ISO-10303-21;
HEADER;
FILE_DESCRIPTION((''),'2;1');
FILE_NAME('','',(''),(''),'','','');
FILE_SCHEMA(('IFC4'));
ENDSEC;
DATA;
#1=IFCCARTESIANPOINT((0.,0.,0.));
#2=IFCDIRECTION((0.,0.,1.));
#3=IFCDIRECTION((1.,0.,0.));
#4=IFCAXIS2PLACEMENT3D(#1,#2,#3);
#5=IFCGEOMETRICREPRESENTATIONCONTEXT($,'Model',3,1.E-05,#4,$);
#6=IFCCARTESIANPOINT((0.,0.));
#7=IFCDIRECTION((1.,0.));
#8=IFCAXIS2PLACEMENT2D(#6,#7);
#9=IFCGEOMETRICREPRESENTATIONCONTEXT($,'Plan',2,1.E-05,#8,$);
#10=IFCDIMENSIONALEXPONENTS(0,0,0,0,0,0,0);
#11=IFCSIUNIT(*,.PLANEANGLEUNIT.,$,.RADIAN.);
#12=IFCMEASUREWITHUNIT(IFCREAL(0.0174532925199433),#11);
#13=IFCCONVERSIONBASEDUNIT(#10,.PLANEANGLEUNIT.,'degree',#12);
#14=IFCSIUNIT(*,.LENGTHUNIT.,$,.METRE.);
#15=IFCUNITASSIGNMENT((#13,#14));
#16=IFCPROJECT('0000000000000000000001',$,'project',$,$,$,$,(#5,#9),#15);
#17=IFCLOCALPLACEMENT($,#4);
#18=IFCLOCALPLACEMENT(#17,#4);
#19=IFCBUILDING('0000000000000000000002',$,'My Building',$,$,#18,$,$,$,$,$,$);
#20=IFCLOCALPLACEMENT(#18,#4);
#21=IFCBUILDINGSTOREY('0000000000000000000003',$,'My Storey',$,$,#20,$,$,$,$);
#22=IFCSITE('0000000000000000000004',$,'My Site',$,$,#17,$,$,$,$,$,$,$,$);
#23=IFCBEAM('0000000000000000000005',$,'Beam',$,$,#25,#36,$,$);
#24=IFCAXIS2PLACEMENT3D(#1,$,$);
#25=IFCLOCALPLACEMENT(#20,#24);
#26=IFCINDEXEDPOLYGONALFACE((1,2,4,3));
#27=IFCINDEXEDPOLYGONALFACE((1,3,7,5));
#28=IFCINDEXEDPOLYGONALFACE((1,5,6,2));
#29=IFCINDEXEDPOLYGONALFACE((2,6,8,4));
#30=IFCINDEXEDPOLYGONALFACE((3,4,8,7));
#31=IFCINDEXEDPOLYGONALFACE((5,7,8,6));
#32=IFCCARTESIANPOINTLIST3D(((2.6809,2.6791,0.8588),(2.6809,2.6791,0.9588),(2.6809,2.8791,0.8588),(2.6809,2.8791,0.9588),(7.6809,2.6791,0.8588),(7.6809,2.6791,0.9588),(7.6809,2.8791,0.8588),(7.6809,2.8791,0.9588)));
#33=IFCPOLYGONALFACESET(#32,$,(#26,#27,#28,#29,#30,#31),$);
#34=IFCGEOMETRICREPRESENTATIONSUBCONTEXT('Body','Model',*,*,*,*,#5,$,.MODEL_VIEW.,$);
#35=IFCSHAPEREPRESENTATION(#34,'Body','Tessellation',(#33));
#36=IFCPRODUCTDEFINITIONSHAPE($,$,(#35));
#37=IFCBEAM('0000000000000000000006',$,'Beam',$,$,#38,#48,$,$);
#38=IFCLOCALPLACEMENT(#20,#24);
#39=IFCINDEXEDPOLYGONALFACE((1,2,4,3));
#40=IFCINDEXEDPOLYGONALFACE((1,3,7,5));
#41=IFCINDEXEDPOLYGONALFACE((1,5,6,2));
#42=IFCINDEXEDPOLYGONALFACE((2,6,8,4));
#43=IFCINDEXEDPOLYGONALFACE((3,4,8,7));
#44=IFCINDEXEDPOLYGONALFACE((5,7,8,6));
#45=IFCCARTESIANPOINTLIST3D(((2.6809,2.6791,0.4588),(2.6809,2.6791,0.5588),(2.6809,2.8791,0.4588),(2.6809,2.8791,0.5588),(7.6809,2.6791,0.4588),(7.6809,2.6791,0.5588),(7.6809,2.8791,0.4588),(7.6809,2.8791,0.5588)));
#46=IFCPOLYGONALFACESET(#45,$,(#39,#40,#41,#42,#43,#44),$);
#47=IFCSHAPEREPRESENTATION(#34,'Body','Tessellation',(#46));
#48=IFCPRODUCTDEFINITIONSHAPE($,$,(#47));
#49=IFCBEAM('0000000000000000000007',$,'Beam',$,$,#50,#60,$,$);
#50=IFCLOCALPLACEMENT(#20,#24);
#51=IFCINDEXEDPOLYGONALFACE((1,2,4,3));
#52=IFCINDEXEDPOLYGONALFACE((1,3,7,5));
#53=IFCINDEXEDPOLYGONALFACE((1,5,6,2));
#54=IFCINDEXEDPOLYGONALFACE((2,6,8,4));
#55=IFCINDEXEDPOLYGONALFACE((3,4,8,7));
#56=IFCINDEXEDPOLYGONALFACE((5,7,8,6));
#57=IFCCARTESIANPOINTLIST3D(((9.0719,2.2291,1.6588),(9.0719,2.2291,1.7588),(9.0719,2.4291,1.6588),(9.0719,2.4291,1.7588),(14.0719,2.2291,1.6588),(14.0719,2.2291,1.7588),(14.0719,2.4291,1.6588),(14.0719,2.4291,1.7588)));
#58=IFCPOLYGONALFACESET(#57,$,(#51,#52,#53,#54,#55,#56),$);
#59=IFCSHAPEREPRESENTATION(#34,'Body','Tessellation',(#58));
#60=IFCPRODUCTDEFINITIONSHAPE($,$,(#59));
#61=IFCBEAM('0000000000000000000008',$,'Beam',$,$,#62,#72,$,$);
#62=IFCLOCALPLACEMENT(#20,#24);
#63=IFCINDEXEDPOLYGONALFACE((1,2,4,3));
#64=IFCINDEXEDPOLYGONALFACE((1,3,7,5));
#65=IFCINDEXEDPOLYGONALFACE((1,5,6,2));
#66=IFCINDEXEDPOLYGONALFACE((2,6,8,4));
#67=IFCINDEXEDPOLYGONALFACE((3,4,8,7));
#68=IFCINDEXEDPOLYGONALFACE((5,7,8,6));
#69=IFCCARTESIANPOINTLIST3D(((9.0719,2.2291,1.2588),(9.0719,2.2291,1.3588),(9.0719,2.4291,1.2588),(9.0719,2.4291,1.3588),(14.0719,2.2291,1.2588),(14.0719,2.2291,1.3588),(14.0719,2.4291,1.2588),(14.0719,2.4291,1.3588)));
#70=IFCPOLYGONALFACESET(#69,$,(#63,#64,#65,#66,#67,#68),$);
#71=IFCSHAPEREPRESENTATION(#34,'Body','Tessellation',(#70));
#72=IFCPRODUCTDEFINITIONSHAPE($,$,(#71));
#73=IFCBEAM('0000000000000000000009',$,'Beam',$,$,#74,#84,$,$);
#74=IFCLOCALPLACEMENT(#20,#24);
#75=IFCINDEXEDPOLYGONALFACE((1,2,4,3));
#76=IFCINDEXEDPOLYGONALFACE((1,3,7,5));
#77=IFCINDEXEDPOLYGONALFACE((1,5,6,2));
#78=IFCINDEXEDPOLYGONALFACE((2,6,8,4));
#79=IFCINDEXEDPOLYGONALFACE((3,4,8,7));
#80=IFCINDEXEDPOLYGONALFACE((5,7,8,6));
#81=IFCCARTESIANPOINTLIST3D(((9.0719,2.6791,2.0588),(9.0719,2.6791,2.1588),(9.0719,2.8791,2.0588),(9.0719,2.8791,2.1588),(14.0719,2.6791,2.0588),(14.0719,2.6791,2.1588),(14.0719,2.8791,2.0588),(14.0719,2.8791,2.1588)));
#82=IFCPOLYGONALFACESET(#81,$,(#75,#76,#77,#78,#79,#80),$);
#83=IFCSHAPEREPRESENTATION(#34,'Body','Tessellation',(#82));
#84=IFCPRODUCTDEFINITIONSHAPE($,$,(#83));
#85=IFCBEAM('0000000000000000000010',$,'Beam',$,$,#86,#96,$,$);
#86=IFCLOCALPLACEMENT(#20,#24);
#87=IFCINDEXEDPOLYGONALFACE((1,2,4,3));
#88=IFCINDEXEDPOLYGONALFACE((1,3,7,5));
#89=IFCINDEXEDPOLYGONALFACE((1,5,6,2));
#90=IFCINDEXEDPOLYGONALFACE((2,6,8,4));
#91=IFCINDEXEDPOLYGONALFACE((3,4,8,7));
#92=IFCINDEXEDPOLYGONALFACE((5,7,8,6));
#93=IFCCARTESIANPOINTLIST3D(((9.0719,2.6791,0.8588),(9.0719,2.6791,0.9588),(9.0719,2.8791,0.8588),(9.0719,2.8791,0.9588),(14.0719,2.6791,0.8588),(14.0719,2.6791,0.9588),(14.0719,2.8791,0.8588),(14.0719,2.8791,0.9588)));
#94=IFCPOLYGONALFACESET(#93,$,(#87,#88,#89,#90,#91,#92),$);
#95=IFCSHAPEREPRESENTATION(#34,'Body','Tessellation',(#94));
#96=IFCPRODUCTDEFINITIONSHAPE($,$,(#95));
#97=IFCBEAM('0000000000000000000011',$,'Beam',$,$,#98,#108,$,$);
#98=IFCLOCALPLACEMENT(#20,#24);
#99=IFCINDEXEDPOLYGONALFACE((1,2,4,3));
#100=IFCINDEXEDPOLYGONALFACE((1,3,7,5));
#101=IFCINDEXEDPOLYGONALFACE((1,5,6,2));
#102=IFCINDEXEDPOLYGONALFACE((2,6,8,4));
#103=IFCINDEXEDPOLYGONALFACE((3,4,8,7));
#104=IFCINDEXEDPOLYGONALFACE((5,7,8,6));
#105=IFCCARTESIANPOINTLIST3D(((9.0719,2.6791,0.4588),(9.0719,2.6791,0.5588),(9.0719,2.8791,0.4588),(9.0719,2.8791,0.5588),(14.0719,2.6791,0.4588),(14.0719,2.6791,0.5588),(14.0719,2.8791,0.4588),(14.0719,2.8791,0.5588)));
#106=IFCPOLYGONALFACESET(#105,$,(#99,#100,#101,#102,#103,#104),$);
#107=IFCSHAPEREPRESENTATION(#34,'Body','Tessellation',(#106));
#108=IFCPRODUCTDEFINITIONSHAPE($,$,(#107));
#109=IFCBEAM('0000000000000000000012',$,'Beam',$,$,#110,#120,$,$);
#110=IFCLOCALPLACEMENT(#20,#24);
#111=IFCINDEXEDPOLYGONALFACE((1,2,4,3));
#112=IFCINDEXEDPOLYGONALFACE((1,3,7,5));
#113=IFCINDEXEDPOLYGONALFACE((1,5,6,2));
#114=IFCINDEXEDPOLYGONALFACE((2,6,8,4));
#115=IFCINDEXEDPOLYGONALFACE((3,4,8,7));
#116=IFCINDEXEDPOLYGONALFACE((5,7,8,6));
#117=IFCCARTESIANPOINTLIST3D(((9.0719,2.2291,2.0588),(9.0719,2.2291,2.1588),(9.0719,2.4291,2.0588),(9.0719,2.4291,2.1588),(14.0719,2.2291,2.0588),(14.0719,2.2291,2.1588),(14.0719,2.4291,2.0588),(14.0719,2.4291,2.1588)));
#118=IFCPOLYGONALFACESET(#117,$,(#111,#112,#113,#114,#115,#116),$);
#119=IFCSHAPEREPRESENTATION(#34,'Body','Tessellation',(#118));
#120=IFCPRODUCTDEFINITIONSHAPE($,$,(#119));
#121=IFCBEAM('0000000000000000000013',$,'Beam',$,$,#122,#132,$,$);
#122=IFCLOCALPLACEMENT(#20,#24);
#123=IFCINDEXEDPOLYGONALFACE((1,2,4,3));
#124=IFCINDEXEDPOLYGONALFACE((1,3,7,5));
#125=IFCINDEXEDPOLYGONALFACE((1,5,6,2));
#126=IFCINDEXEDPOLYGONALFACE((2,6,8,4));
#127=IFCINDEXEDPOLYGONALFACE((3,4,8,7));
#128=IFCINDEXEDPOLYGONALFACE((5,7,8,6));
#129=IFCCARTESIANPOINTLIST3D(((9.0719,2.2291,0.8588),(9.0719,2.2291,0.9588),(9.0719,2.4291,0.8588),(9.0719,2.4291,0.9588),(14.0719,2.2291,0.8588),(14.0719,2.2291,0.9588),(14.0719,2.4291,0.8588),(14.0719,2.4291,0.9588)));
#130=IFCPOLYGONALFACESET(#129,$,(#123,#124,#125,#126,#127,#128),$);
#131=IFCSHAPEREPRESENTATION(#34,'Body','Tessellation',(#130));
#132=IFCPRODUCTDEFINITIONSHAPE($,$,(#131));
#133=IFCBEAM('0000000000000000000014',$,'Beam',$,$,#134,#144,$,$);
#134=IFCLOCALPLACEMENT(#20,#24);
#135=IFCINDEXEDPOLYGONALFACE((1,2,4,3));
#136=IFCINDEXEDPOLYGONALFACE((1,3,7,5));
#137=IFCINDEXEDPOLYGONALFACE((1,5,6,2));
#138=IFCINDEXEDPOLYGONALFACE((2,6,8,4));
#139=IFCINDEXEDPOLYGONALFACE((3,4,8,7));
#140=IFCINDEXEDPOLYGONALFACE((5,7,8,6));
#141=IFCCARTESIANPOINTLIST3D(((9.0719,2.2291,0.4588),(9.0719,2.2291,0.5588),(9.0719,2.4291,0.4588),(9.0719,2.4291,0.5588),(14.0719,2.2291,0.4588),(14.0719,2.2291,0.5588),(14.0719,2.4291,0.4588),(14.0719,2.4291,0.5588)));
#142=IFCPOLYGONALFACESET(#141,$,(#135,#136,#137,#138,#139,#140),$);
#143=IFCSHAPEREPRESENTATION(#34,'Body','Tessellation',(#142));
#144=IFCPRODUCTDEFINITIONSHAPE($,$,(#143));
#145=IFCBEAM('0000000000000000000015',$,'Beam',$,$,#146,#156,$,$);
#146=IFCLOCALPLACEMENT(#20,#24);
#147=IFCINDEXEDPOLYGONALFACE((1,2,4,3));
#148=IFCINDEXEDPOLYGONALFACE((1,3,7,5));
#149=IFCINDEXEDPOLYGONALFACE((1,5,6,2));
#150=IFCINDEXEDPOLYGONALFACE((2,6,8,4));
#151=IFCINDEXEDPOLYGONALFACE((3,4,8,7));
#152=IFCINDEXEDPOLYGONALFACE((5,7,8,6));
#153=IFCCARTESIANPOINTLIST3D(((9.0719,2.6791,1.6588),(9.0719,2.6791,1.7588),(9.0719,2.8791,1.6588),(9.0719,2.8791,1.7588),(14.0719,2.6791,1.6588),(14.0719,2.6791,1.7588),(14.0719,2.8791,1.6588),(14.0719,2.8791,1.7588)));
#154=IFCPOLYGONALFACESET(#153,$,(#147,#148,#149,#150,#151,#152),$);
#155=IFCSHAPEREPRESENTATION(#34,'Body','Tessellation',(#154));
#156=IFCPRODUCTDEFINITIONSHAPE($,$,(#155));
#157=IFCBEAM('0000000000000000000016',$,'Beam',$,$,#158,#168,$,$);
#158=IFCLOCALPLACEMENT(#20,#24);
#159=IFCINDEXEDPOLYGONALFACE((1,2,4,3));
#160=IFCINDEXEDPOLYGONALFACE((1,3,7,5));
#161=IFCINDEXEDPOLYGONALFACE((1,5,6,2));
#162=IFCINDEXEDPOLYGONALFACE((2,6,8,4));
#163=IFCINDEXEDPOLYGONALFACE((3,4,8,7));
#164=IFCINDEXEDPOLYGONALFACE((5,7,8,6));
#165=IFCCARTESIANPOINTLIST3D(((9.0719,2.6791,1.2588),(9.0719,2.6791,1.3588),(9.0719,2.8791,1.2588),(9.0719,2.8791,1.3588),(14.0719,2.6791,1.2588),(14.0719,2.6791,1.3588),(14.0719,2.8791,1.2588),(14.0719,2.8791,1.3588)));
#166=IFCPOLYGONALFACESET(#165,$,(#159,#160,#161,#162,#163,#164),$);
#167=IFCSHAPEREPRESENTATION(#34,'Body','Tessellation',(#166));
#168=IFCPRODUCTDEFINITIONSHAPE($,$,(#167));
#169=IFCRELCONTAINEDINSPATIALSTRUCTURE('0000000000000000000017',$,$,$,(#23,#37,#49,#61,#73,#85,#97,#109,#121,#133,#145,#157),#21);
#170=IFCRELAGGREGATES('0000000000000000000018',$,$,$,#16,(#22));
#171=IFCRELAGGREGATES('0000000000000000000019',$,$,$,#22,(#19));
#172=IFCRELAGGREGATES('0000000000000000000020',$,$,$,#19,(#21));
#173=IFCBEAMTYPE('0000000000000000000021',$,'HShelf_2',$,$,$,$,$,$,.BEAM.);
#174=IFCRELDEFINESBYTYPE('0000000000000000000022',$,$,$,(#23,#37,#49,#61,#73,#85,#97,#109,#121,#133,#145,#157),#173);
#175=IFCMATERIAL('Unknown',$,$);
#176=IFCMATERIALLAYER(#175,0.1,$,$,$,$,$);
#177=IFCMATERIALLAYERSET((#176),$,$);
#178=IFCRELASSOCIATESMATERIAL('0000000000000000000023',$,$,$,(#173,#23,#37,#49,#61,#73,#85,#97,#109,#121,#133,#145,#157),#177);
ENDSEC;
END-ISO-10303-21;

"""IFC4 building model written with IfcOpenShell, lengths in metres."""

from ifc_helpers import new_model, entity, si_unit, converted_unit, frame, origin_with_axes, origin_2d_with_axis, place, context, subcontext, project, spatial, indexed_curve, outline, extrude, material, layer, layer_set, layer_usage, type_object, element, save


model = new_model("IFC4")

# Units and contexts
model_context = context("Model", 3, precision=1e-05, world=origin_with_axes())
plan_context = context("Plan", 2, precision=1e-05, world=origin_2d_with_axis())
body_context_1 = subcontext(model_context, "Body", "Model", "MODEL_VIEW")
ifc_project = project(units=[converted_unit("PLANEANGLEUNIT", "degree", entity("IfcReal", 0.0174532925199433), si_unit("PLANEANGLEUNIT", "RADIAN"), dimensions=[0, 0, 0, 0, 0, 0, 0]), si_unit("LENGTHUNIT", "METRE")], contexts=[model_context, plan_context])

# Site, building, storey
site_placement = place(None, origin_with_axes())
site = spatial("IfcSite", under=ifc_project, at=site_placement, Name="My Site")
building_placement = place(site_placement, origin_with_axes())
building = spatial("IfcBuilding", under=site, at=building_placement, Name="My Building")
storey_placement = place(building_placement, origin_with_axes())
storey = spatial("IfcBuildingStorey", under=building, at=storey_placement, Name="My Storey")

# Shared definitions
ifc_material = material(Name="Unknown")

# Beams
ifc_layer_1 = layer(ifc_material, 0.1)
ifc_layer_set_1 = layer_set([ifc_layer_1])
beam_type_1 = type_object("IfcBeamType", Name="HShelf_2", PredefinedType="BEAM", material=ifc_layer_set_1)
ifc_layer_usage_1 = layer_usage(ifc_layer_set_1, "AXIS3", "POSITIVE", -0.1)
beam_1_placement = place(storey_placement, frame((2.6809, 2.8791, 0.9588), z_axis=(0.0, 0.0, 1.0), x_axis=(1.0, 0.0, 0.0)))
element("IfcBeam", 1, at=beam_1_placement, inside=storey, type_object=beam_type_1, material=ifc_layer_usage_1, Name="Beam", context=body_context_1, shape_type="SweptSolid", body=[
    extrude(outline(indexed_curve([(0.0, 0.0), (0.0, -0.2), (5.0, -0.2), (5.0, 0.0), (0.0, 0.0)])), frame((0.0, 0.0, -0.1), z_axis=(0.0, 0.0, 1.0), x_axis=(1.0, 0.0, 0.0)), (0.0, 0.0, 1.0), 0.1),
])
ifc_layer_usage_2 = layer_usage(ifc_layer_set_1, "AXIS3", "POSITIVE", -0.1)
beam_2_placement = place(storey_placement, frame((2.6809, 2.8791, 0.5588), z_axis=(0.0, 0.0, 1.0), x_axis=(1.0, 0.0, 0.0)))
element("IfcBeam", 2, at=beam_2_placement, inside=storey, type_object=beam_type_1, material=ifc_layer_usage_2, Name="Beam", context=body_context_1, shape_type="SweptSolid", body=[
    extrude(outline(indexed_curve([(0.0, 0.0), (0.0, -0.2), (5.0, -0.2), (5.0, 0.0), (0.0, 0.0)])), frame((0.0, 0.0, -0.1), z_axis=(0.0, 0.0, 1.0), x_axis=(1.0, 0.0, 0.0)), (0.0, 0.0, 1.0), 0.1),
])
ifc_layer_usage_3 = layer_usage(ifc_layer_set_1, "AXIS3", "POSITIVE", -0.1)
beam_3_placement = place(storey_placement, frame((9.0719, 2.4291, 1.7588), z_axis=(0.0, 0.0, 1.0), x_axis=(1.0, 0.0, 0.0)))
element("IfcBeam", 3, at=beam_3_placement, inside=storey, type_object=beam_type_1, material=ifc_layer_usage_3, Name="Beam", context=body_context_1, shape_type="SweptSolid", body=[
    extrude(outline(indexed_curve([(0.0, 0.0), (0.0, -0.2), (5.0, -0.2), (5.0, 0.0), (0.0, 0.0)])), frame((0.0, 0.0, -0.1), z_axis=(0.0, 0.0, 1.0), x_axis=(1.0, 0.0, 0.0)), (0.0, 0.0, 1.0), 0.1),
])
ifc_layer_usage_4 = layer_usage(ifc_layer_set_1, "AXIS3", "POSITIVE", -0.1)
beam_4_placement = place(storey_placement, frame((9.0719, 2.4291, 1.3588), z_axis=(0.0, 0.0, 1.0), x_axis=(1.0, 0.0, 0.0)))
element("IfcBeam", 4, at=beam_4_placement, inside=storey, type_object=beam_type_1, material=ifc_layer_usage_4, Name="Beam", context=body_context_1, shape_type="SweptSolid", body=[
    extrude(outline(indexed_curve([(0.0, 0.0), (0.0, -0.2), (5.0, -0.2), (5.0, 0.0), (0.0, 0.0)])), frame((0.0, 0.0, -0.1), z_axis=(0.0, 0.0, 1.0), x_axis=(1.0, 0.0, 0.0)), (0.0, 0.0, 1.0), 0.1),
])
ifc_layer_usage_5 = layer_usage(ifc_layer_set_1, "AXIS3", "POSITIVE", -0.1)
beam_5_placement = place(storey_placement, frame((9.0719, 2.8791, 2.1588), z_axis=(0.0, 0.0, 1.0), x_axis=(1.0, 0.0, 0.0)))
element("IfcBeam", 5, at=beam_5_placement, inside=storey, type_object=beam_type_1, material=ifc_layer_usage_5, Name="Beam", context=body_context_1, shape_type="SweptSolid", body=[
    extrude(outline(indexed_curve([(0.0, 0.0), (0.0, -0.2), (5.0, -0.2), (5.0, 0.0), (0.0, 0.0)])), frame((0.0, 0.0, -0.1), z_axis=(0.0, 0.0, 1.0), x_axis=(1.0, 0.0, 0.0)), (0.0, 0.0, 1.0), 0.1),
])
ifc_layer_usage_6 = layer_usage(ifc_layer_set_1, "AXIS3", "POSITIVE", -0.1)
beam_6_placement = place(storey_placement, frame((9.0719, 2.8791, 0.9588), z_axis=(0.0, 0.0, 1.0), x_axis=(1.0, 0.0, 0.0)))
element("IfcBeam", 6, at=beam_6_placement, inside=storey, type_object=beam_type_1, material=ifc_layer_usage_6, Name="Beam", context=body_context_1, shape_type="SweptSolid", body=[
    extrude(outline(indexed_curve([(0.0, 0.0), (0.0, -0.2), (5.0, -0.2), (5.0, 0.0), (0.0, 0.0)])), frame((0.0, 0.0, -0.1), z_axis=(0.0, 0.0, 1.0), x_axis=(1.0, 0.0, 0.0)), (0.0, 0.0, 1.0), 0.1),
])
ifc_layer_usage_7 = layer_usage(ifc_layer_set_1, "AXIS3", "POSITIVE", -0.1)
beam_7_placement = place(storey_placement, frame((9.0719, 2.8791, 0.5588), z_axis=(0.0, 0.0, 1.0), x_axis=(1.0, 0.0, 0.0)))
element("IfcBeam", 7, at=beam_7_placement, inside=storey, type_object=beam_type_1, material=ifc_layer_usage_7, Name="Beam", context=body_context_1, shape_type="SweptSolid", body=[
    extrude(outline(indexed_curve([(0.0, 0.0), (0.0, -0.2), (5.0, -0.2), (5.0, 0.0), (0.0, 0.0)])), frame((0.0, 0.0, -0.1), z_axis=(0.0, 0.0, 1.0), x_axis=(1.0, 0.0, 0.0)), (0.0, 0.0, 1.0), 0.1),
])
ifc_layer_usage_8 = layer_usage(ifc_layer_set_1, "AXIS3", "POSITIVE", -0.1)
beam_8_placement = place(storey_placement, frame((9.0719, 2.4291, 2.1588), z_axis=(0.0, 0.0, 1.0), x_axis=(1.0, 0.0, 0.0)))
element("IfcBeam", 8, at=beam_8_placement, inside=storey, type_object=beam_type_1, material=ifc_layer_usage_8, Name="Beam", context=body_context_1, shape_type="SweptSolid", body=[
    extrude(outline(indexed_curve([(0.0, 0.0), (0.0, -0.2), (5.0, -0.2), (5.0, 0.0), (0.0, 0.0)])), frame((0.0, 0.0, -0.1), z_axis=(0.0, 0.0, 1.0), x_axis=(1.0, 0.0, 0.0)), (0.0, 0.0, 1.0), 0.1),
])
ifc_layer_usage_9 = layer_usage(ifc_layer_set_1, "AXIS3", "POSITIVE", -0.1)
beam_9_placement = place(storey_placement, frame((9.0719, 2.4291, 0.9588), z_axis=(0.0, 0.0, 1.0), x_axis=(1.0, 0.0, 0.0)))
element("IfcBeam", 9, at=beam_9_placement, inside=storey, type_object=beam_type_1, material=ifc_layer_usage_9, Name="Beam", context=body_context_1, shape_type="SweptSolid", body=[
    extrude(outline(indexed_curve([(0.0, 0.0), (0.0, -0.2), (5.0, -0.2), (5.0, 0.0), (0.0, 0.0)])), frame((0.0, 0.0, -0.1), z_axis=(0.0, 0.0, 1.0), x_axis=(1.0, 0.0, 0.0)), (0.0, 0.0, 1.0), 0.1),
])
ifc_layer_usage_10 = layer_usage(ifc_layer_set_1, "AXIS3", "POSITIVE", -0.1)
beam_10_placement = place(storey_placement, frame((9.0719, 2.4291, 0.5588), z_axis=(0.0, 0.0, 1.0), x_axis=(1.0, 0.0, 0.0)))
element("IfcBeam", 10, at=beam_10_placement, inside=storey, type_object=beam_type_1, material=ifc_layer_usage_10, Name="Beam", context=body_context_1, shape_type="SweptSolid", body=[
    extrude(outline(indexed_curve([(0.0, 0.0), (0.0, -0.2), (5.0, -0.2), (5.0, 0.0), (0.0, 0.0)])), frame((0.0, 0.0, -0.1), z_axis=(0.0, 0.0, 1.0), x_axis=(1.0, 0.0, 0.0)), (0.0, 0.0, 1.0), 0.1),
])
ifc_layer_usage_11 = layer_usage(ifc_layer_set_1, "AXIS3", "POSITIVE", -0.1)
beam_11_placement = place(storey_placement, frame((9.0719, 2.8791, 1.7588), z_axis=(0.0, 0.0, 1.0), x_axis=(1.0, 0.0, 0.0)))
element("IfcBeam", 11, at=beam_11_placement, inside=storey, type_object=beam_type_1, material=ifc_layer_usage_11, Name="Beam", context=body_context_1, shape_type="SweptSolid", body=[
    extrude(outline(indexed_curve([(0.0, 0.0), (0.0, -0.2), (5.0, -0.2), (5.0, 0.0), (0.0, 0.0)])), frame((0.0, 0.0, -0.1), z_axis=(0.0, 0.0, 1.0), x_axis=(1.0, 0.0, 0.0)), (0.0, 0.0, 1.0), 0.1),
])
ifc_layer_usage_12 = layer_usage(ifc_layer_set_1, "AXIS3", "POSITIVE", -0.1)
beam_12_placement = place(storey_placement, frame((9.0719, 2.8791, 1.3588), z_axis=(0.0, 0.0, 1.0), x_axis=(1.0, 0.0, 0.0)))
element("IfcBeam", 12, at=beam_12_placement, inside=storey, type_object=beam_type_1, material=ifc_layer_usage_12, Name="Beam", context=body_context_1, shape_type="SweptSolid", body=[
    extrude(outline(indexed_curve([(0.0, 0.0), (0.0, -0.2), (5.0, -0.2), (5.0, 0.0), (0.0, 0.0)])), frame((0.0, 0.0, -0.1), z_axis=(0.0, 0.0, 1.0), x_axis=(1.0, 0.0, 0.0)), (0.0, 0.0, 1.0), 0.1),
])

save(model, "model.ifc")
